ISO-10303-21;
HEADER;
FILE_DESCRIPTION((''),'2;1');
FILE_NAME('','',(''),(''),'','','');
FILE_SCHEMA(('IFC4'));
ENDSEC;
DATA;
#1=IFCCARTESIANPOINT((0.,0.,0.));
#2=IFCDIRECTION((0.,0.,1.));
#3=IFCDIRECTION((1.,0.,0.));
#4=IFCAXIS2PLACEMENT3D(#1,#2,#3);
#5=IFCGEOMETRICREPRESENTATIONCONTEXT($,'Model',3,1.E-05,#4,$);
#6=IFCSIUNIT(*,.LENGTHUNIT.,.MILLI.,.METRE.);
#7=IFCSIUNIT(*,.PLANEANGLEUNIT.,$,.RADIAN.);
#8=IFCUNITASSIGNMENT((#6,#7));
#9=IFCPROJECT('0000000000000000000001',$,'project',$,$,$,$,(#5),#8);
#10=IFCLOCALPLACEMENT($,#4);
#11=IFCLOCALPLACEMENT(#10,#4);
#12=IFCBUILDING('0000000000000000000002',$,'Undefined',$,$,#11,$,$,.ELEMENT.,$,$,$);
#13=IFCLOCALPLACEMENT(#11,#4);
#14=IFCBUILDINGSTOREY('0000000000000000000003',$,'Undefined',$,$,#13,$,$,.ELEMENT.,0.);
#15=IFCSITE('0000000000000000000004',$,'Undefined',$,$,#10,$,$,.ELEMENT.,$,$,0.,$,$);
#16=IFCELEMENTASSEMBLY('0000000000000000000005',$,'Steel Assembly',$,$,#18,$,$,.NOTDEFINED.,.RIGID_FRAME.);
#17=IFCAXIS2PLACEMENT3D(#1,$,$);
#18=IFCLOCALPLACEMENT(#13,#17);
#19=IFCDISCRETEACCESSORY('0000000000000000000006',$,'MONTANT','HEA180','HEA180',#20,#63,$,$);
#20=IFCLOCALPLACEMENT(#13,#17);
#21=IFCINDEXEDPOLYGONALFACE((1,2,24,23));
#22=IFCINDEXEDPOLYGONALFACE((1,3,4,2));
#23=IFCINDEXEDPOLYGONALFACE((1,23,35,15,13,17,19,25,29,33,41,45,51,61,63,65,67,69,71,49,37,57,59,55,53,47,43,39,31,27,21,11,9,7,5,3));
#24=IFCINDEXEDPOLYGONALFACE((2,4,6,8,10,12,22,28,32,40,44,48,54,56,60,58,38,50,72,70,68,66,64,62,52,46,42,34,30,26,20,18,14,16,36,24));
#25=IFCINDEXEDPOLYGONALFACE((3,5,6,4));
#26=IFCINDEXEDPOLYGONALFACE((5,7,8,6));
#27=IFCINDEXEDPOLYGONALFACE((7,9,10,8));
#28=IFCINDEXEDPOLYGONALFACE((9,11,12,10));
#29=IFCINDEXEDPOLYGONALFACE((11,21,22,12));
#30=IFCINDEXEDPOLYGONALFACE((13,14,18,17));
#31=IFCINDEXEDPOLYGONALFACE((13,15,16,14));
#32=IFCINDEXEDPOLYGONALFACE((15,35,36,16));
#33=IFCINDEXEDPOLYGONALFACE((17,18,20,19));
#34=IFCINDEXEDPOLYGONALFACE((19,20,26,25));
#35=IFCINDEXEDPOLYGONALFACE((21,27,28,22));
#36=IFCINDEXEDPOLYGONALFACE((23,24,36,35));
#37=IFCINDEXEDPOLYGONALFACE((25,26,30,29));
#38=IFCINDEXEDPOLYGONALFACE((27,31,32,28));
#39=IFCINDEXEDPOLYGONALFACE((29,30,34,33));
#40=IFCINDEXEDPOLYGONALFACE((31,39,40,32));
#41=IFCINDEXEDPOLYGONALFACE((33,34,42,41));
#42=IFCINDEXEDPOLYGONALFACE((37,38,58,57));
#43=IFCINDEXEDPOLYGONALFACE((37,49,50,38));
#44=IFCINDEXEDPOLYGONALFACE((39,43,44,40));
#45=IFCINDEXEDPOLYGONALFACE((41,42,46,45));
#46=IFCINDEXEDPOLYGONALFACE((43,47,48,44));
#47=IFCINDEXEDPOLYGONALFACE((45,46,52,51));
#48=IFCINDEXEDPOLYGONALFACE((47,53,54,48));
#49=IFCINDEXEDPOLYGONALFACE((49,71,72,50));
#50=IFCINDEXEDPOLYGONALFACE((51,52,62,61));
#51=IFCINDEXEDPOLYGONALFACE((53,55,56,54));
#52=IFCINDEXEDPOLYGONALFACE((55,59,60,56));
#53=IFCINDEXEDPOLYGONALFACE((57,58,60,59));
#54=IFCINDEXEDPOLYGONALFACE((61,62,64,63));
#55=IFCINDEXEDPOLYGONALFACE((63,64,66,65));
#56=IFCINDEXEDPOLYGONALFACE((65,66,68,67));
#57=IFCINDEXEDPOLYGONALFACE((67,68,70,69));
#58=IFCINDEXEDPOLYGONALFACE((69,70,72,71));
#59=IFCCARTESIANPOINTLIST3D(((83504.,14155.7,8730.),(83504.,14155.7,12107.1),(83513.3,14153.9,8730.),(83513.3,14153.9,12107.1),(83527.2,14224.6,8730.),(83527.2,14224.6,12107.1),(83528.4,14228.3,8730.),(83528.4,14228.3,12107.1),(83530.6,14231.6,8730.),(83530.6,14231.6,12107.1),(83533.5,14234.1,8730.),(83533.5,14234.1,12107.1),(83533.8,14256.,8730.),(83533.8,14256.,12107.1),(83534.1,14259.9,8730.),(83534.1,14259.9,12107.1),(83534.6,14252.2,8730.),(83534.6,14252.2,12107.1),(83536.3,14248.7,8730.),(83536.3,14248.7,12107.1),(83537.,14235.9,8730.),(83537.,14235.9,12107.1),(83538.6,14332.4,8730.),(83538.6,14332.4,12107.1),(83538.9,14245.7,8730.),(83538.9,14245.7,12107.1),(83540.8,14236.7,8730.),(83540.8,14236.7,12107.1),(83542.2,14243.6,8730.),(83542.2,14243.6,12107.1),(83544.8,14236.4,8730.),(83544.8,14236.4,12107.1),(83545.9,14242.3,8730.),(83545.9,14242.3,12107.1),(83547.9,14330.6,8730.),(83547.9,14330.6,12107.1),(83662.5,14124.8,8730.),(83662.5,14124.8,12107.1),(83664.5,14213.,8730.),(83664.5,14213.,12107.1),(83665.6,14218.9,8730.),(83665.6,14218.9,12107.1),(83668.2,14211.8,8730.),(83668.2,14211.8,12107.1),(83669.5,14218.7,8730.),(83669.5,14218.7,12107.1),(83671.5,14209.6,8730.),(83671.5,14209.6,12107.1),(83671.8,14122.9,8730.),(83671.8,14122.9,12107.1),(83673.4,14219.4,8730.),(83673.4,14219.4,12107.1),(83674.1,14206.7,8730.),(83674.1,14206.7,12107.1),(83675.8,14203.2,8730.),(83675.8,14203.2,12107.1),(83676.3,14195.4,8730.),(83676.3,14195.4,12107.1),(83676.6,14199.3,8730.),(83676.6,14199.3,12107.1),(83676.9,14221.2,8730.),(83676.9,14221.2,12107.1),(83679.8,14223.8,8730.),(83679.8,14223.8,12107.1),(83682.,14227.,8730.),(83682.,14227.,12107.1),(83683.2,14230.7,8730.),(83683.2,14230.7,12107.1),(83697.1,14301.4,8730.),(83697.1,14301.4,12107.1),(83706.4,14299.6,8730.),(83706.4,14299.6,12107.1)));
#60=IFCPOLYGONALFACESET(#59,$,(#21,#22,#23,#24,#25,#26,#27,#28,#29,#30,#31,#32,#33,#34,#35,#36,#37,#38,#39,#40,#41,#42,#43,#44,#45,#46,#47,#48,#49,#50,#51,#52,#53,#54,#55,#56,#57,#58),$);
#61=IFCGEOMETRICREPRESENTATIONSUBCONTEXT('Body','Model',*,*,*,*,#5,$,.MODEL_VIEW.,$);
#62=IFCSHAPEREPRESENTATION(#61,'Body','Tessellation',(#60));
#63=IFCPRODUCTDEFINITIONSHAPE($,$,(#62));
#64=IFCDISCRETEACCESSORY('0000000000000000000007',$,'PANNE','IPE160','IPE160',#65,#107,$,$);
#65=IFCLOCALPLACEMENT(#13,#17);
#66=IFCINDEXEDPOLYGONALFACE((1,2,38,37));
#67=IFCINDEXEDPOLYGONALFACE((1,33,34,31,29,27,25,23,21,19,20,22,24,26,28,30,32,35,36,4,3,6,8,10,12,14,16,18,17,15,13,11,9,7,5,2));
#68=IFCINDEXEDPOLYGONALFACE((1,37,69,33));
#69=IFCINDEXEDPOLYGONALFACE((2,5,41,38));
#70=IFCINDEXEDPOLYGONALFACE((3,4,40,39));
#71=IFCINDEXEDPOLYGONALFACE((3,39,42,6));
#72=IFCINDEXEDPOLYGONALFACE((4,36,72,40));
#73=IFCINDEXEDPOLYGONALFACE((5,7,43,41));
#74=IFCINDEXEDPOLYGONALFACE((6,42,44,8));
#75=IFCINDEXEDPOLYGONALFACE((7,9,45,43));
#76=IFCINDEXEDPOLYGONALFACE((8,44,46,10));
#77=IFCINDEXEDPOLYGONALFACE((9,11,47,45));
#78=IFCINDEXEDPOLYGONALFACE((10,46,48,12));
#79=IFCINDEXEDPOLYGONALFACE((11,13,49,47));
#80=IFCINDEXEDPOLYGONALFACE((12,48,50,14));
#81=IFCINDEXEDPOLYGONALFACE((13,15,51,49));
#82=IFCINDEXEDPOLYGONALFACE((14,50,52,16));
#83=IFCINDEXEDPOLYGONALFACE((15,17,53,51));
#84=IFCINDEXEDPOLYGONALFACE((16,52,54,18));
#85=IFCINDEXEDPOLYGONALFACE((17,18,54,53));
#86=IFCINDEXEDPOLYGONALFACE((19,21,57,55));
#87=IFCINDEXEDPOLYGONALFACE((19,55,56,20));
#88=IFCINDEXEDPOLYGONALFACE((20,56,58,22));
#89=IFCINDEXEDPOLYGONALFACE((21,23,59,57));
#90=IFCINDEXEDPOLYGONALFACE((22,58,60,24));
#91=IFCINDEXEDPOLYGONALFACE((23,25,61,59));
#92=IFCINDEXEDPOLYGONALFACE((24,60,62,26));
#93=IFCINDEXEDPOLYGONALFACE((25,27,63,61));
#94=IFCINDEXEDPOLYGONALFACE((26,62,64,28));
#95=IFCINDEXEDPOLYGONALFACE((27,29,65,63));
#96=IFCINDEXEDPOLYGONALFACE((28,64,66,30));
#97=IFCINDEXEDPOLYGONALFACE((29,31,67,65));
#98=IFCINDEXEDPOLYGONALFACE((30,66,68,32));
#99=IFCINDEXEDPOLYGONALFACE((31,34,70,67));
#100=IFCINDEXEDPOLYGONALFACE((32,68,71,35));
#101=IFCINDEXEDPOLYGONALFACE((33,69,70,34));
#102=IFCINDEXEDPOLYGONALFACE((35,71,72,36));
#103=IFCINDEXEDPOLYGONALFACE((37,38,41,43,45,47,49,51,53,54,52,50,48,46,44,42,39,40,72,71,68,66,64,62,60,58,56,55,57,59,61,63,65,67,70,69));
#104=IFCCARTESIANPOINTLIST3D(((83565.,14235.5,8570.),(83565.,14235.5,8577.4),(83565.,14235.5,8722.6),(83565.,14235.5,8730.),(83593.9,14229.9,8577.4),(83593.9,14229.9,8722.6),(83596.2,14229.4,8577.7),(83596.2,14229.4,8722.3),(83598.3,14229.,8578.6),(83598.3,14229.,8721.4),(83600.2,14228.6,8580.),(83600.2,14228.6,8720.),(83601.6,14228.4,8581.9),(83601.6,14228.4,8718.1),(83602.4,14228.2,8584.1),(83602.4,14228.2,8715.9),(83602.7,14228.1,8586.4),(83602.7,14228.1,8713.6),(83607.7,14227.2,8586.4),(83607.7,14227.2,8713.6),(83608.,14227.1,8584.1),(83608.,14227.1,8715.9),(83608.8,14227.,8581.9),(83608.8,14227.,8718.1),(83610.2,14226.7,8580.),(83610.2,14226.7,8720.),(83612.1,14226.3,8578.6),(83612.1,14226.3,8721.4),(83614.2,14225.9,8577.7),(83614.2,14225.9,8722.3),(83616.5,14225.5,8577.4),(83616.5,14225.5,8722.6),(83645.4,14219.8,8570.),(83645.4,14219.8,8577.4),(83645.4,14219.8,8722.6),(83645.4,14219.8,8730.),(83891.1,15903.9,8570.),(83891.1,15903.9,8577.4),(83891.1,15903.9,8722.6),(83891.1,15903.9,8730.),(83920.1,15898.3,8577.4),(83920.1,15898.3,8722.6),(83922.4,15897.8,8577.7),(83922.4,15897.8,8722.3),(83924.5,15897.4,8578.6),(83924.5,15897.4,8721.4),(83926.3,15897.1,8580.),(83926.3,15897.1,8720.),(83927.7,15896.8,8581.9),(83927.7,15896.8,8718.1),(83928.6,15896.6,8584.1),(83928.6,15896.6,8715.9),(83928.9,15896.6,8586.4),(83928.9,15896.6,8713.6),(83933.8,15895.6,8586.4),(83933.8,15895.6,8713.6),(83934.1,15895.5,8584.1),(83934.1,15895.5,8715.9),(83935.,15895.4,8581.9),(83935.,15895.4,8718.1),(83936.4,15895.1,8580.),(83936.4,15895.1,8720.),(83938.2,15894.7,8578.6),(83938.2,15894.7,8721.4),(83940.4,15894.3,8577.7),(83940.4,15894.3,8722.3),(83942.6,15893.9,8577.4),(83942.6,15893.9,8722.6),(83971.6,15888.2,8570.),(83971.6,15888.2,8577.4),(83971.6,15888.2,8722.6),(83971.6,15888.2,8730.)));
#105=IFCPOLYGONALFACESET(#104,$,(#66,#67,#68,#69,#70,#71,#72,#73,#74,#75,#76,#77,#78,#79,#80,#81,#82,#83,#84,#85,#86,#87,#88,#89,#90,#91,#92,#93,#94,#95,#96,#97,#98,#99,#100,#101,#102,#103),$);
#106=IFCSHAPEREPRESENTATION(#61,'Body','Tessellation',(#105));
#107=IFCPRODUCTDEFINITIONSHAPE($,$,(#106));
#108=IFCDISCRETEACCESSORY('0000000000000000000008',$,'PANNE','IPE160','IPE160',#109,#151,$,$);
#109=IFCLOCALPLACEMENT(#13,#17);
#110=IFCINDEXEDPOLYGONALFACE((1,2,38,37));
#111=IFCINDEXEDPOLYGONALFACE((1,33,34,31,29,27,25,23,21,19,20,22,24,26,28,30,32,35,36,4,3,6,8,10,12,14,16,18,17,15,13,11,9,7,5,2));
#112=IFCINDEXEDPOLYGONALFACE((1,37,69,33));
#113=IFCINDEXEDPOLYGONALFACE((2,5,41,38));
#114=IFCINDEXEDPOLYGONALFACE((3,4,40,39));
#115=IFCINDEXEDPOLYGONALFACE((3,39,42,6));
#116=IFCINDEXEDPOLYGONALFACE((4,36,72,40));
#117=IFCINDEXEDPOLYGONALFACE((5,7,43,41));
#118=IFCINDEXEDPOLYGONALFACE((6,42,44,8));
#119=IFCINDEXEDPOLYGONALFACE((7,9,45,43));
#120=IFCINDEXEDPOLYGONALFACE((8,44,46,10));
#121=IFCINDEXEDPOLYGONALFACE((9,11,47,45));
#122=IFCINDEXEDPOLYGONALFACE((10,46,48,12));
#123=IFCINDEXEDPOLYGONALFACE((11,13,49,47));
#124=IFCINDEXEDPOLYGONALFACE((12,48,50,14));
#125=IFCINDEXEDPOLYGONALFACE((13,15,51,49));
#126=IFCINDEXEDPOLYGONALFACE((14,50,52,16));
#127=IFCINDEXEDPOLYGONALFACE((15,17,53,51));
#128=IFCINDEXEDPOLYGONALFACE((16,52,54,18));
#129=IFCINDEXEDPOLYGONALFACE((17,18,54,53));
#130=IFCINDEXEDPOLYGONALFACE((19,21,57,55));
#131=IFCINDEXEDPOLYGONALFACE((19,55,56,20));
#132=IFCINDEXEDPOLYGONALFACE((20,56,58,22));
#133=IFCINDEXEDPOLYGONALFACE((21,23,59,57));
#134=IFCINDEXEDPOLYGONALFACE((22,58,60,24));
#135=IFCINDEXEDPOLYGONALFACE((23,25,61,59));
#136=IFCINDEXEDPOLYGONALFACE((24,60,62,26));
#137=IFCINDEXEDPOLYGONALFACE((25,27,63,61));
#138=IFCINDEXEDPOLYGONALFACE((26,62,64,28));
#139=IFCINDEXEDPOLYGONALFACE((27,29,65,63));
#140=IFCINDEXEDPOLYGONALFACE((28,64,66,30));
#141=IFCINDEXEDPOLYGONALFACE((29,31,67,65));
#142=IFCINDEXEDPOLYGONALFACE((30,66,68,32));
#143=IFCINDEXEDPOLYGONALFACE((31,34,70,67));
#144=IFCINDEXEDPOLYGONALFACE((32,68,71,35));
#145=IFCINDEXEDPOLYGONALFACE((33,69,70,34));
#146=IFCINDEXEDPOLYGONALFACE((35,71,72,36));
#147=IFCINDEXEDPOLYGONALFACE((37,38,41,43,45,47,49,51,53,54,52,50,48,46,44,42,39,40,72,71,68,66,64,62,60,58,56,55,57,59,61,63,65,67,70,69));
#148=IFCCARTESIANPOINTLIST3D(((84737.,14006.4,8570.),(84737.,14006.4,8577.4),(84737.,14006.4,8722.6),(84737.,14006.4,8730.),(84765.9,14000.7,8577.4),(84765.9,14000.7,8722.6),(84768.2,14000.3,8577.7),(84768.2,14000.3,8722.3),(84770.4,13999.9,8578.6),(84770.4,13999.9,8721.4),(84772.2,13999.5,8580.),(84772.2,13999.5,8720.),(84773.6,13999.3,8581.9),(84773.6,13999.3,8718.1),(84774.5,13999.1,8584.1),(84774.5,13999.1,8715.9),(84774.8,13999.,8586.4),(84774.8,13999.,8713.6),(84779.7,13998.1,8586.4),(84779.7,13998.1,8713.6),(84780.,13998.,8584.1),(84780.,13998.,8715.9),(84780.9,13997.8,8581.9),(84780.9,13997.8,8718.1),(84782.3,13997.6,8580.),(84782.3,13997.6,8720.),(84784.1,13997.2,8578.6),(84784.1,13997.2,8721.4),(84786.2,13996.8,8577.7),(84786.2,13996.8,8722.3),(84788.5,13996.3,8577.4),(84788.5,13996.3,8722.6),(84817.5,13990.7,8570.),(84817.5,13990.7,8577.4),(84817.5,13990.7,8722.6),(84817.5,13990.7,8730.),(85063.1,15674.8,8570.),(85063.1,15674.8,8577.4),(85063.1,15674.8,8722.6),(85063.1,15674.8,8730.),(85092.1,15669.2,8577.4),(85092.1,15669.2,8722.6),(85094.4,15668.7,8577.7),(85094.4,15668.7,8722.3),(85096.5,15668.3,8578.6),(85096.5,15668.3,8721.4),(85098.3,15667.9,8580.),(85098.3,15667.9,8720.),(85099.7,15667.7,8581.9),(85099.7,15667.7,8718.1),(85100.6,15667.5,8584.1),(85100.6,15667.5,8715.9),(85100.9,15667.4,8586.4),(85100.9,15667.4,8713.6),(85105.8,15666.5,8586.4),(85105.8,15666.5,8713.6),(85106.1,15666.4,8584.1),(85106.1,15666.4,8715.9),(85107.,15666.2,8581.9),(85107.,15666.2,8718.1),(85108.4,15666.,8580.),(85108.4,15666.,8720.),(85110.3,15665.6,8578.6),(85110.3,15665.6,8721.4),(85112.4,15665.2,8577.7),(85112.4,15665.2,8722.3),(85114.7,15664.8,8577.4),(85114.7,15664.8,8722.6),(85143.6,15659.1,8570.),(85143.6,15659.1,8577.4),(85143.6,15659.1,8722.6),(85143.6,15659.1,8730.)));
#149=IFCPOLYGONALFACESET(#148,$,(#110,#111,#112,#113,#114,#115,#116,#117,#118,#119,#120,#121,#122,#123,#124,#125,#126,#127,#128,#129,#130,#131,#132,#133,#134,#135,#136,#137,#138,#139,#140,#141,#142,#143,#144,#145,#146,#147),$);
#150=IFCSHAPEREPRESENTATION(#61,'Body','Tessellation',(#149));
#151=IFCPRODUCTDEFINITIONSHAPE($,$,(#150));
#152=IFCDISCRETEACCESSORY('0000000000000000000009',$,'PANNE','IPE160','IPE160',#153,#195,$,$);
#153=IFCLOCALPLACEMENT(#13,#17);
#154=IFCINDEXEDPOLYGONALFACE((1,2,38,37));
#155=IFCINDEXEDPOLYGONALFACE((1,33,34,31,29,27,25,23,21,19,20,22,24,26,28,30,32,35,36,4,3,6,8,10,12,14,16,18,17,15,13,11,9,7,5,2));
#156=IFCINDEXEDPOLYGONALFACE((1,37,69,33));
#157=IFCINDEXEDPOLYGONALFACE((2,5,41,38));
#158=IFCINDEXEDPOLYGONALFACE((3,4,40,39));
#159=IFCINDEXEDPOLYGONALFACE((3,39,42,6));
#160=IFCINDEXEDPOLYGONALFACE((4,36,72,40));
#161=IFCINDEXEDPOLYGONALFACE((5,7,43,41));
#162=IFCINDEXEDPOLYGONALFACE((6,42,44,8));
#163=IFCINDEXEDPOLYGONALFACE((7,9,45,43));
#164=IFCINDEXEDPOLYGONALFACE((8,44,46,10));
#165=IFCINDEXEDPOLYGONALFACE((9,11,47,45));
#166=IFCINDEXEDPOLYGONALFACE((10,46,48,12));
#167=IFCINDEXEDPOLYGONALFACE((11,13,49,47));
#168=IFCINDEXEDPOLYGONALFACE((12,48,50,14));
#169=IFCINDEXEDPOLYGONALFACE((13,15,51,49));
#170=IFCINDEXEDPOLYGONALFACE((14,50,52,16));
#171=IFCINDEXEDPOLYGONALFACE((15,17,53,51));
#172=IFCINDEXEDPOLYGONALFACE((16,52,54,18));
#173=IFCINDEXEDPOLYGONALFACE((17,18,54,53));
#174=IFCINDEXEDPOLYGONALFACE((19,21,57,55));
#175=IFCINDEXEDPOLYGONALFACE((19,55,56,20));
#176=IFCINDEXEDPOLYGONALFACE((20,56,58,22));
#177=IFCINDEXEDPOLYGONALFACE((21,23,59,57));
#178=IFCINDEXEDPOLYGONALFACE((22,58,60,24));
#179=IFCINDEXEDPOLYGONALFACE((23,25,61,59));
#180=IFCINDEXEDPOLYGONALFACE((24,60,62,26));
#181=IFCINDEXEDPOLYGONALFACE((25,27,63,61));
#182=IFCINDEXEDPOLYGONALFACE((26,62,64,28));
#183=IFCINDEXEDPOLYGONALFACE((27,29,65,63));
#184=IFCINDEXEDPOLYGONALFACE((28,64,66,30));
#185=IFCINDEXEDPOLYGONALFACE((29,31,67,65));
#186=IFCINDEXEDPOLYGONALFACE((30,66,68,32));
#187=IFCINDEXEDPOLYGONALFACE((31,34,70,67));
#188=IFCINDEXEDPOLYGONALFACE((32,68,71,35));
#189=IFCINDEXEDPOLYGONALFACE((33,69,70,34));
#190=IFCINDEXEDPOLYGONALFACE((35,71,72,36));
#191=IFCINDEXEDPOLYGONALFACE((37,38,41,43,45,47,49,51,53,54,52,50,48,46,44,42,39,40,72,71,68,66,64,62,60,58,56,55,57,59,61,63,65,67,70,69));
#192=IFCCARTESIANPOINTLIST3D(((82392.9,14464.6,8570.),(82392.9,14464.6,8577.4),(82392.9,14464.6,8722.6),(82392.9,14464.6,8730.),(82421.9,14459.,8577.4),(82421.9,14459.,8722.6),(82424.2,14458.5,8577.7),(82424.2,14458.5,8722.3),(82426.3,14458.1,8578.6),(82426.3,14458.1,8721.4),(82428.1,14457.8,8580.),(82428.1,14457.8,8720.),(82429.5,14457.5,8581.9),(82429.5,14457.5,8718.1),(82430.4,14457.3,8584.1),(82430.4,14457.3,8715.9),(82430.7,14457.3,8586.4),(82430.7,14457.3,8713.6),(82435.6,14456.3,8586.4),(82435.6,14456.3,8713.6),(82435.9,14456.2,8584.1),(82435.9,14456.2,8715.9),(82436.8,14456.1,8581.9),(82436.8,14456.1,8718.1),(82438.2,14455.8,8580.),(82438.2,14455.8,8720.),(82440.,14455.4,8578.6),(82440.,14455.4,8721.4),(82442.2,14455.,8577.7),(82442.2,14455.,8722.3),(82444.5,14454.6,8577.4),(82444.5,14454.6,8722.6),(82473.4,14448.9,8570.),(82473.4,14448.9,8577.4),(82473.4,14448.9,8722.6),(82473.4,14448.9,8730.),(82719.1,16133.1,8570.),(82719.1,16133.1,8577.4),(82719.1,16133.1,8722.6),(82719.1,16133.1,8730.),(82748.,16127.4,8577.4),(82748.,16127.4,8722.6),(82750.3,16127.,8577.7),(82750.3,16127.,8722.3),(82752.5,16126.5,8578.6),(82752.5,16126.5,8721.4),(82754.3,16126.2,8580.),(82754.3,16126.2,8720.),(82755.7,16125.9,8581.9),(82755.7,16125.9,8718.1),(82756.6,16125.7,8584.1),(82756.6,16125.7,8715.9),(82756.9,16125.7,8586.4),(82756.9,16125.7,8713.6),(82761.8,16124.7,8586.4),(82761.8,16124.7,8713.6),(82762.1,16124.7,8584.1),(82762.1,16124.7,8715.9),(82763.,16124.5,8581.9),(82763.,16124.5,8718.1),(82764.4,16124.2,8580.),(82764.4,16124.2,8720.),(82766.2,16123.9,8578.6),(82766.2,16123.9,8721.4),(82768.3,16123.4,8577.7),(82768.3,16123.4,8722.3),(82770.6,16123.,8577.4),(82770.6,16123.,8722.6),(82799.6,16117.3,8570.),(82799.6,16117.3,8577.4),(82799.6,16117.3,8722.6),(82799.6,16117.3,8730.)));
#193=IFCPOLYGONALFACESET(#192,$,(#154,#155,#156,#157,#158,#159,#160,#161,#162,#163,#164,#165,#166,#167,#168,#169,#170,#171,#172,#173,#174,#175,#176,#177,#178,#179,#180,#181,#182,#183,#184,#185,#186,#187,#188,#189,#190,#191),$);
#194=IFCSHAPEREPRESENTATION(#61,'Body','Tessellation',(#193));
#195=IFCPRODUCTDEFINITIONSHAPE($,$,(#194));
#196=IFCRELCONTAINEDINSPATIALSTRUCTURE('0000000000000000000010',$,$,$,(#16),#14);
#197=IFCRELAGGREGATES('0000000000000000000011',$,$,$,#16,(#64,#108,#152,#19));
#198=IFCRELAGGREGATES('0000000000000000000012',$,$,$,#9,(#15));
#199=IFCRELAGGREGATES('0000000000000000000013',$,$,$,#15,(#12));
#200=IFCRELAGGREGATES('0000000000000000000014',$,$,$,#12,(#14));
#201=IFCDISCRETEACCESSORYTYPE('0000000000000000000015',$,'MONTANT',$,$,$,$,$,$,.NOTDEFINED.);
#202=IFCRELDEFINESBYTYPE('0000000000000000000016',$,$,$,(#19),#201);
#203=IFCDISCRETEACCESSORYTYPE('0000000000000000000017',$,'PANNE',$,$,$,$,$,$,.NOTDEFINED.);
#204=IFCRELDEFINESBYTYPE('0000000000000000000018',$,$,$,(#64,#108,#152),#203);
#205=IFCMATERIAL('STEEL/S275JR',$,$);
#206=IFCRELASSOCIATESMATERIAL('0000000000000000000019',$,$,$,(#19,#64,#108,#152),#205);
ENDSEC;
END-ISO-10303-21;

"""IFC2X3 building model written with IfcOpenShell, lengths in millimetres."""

from ifc_helpers import new_model, si_unit, frame, origin_with_axes, origin_2d_with_axis, place, context, subcontext, project, spatial, i_section, extrude, material, type_object, element, aggregate, save


model = new_model("IFC2X3")

# Units and contexts
model_context = context("Model", 3, precision=1e-05, world=origin_with_axes())
body_context = subcontext(model_context, "Body", "Model", "MODEL_VIEW")
ifc_project = project(units=[si_unit("LENGTHUNIT", "METRE", prefix="MILLI"), si_unit("PLANEANGLEUNIT", "RADIAN")], contexts=[model_context])

# Site, building, storey
site_placement = place(None, origin_with_axes())
site = spatial("IfcSite", under=ifc_project, at=site_placement, Name="Undefined", CompositionType="ELEMENT", RefElevation=0.0)
building_placement = place(site_placement, origin_with_axes())
building = spatial("IfcBuilding", under=site, at=building_placement, Name="Undefined", CompositionType="ELEMENT")
storey_placement = place(building_placement, origin_with_axes())
storey = spatial("IfcBuildingStorey", under=building, at=storey_placement, Name="Undefined", CompositionType="ELEMENT", Elevation=0.0)

# Shared definitions
ifc_material_1 = material(Name="STEEL/S275JR")

# Element assembly, discrete accessories
assembly_1_placement = place(storey_placement, origin_with_axes())
assembly_1 = element("IfcElementAssembly", 1, at=assembly_1_placement, inside=storey, Name="Steel Assembly", AssemblyPlace="NOTDEFINED", PredefinedType="RIGID_FRAME")
discrete_accessory_type_1 = type_object("IfcDiscreteAccessoryType", Name="MONTANT")
discrete_accessory_1_placement = place(assembly_1_placement, frame((83605.2, 14227.7, 12107.1), z_axis=(-0.981422, 0.191859, 0.0), x_axis=(0.0, 0.0, -1.0)))
discrete_accessory_1 = element("IfcDiscreteAccessory", 2, at=discrete_accessory_1_placement, type_object=discrete_accessory_type_1, material=ifc_material_1, Name="MONTANT", Description="HEA180", ObjectType="HEA180", context=body_context, shape_type="SweptSolid", body=[
    extrude(i_section(OverallWidth=180.0, OverallDepth=171.0, WebThickness=6.0, FlangeThickness=9.5, FilletRadius=15.0, at=origin_2d_with_axis()), frame((3377.1, 0.0, 0.0), z_axis=(-1.0, 0.0, 0.0), x_axis=(0.0, -1.0, 0.0)), (0.0, 0.0, 1.0), 3377.1),
])
discrete_accessory_type_2 = type_object("IfcDiscreteAccessoryType", Name="PANNE")
discrete_accessory_2_placement = place(assembly_1_placement, frame((83605.2, 14227.7, 8650.0), z_axis=(0.0, 0.0, 1.0), x_axis=(0.191859, 0.981422, 0.0)))
discrete_accessory_2 = element("IfcDiscreteAccessory", 3, at=discrete_accessory_2_placement, type_object=discrete_accessory_type_2, material=ifc_material_1, Name="PANNE", Description="IPE160", ObjectType="IPE160", context=body_context, shape_type="SweptSolid", body=[
    extrude(i_section(OverallWidth=82.0, OverallDepth=160.0, WebThickness=5.0, FlangeThickness=7.4, FilletRadius=9.0, at=origin_2d_with_axis()), frame((1700.0, 0.0, 0.0), z_axis=(-1.0, 0.0, 0.0), x_axis=(0.0, -1.0, 0.0)), (0.0, 0.0, 1.0), 1700.0),
])
discrete_accessory_3_placement = place(assembly_1_placement, frame((84777.2, 13998.5, 8650.0), z_axis=(0.0, 0.0, 1.0), x_axis=(0.191859, 0.981422, 0.0)))
discrete_accessory_3 = element("IfcDiscreteAccessory", 4, at=discrete_accessory_3_placement, type_object=discrete_accessory_type_2, material=ifc_material_1, Name="PANNE", Description="IPE160", ObjectType="IPE160", context=body_context, shape_type="SweptSolid", body=[
    extrude(i_section(OverallWidth=82.0, OverallDepth=160.0, WebThickness=5.0, FlangeThickness=7.4, FilletRadius=9.0, at=origin_2d_with_axis()), frame((1700.0, 0.0, 0.0), z_axis=(-1.0, 0.0, 0.0), x_axis=(0.0, -1.0, 0.0)), (0.0, 0.0, 1.0), 1700.0),
])
discrete_accessory_4_placement = place(assembly_1_placement, frame((82433.2, 14456.8, 8650.0), z_axis=(0.0, 0.0, 1.0), x_axis=(0.191859, 0.981422, 0.0)))
discrete_accessory_4 = element("IfcDiscreteAccessory", 5, at=discrete_accessory_4_placement, type_object=discrete_accessory_type_2, material=ifc_material_1, Name="PANNE", Description="IPE160", ObjectType="IPE160", context=body_context, shape_type="SweptSolid", body=[
    extrude(i_section(OverallWidth=82.0, OverallDepth=160.0, WebThickness=5.0, FlangeThickness=7.4, FilletRadius=9.0, at=origin_2d_with_axis()), frame((1700.0, 0.0, 0.0), z_axis=(-1.0, 0.0, 0.0), x_axis=(0.0, -1.0, 0.0)), (0.0, 0.0, 1.0), 1700.0),
])
aggregate(assembly_1, [discrete_accessory_2, discrete_accessory_3, discrete_accessory_4, discrete_accessory_1])

save(model, "model.ifc")
